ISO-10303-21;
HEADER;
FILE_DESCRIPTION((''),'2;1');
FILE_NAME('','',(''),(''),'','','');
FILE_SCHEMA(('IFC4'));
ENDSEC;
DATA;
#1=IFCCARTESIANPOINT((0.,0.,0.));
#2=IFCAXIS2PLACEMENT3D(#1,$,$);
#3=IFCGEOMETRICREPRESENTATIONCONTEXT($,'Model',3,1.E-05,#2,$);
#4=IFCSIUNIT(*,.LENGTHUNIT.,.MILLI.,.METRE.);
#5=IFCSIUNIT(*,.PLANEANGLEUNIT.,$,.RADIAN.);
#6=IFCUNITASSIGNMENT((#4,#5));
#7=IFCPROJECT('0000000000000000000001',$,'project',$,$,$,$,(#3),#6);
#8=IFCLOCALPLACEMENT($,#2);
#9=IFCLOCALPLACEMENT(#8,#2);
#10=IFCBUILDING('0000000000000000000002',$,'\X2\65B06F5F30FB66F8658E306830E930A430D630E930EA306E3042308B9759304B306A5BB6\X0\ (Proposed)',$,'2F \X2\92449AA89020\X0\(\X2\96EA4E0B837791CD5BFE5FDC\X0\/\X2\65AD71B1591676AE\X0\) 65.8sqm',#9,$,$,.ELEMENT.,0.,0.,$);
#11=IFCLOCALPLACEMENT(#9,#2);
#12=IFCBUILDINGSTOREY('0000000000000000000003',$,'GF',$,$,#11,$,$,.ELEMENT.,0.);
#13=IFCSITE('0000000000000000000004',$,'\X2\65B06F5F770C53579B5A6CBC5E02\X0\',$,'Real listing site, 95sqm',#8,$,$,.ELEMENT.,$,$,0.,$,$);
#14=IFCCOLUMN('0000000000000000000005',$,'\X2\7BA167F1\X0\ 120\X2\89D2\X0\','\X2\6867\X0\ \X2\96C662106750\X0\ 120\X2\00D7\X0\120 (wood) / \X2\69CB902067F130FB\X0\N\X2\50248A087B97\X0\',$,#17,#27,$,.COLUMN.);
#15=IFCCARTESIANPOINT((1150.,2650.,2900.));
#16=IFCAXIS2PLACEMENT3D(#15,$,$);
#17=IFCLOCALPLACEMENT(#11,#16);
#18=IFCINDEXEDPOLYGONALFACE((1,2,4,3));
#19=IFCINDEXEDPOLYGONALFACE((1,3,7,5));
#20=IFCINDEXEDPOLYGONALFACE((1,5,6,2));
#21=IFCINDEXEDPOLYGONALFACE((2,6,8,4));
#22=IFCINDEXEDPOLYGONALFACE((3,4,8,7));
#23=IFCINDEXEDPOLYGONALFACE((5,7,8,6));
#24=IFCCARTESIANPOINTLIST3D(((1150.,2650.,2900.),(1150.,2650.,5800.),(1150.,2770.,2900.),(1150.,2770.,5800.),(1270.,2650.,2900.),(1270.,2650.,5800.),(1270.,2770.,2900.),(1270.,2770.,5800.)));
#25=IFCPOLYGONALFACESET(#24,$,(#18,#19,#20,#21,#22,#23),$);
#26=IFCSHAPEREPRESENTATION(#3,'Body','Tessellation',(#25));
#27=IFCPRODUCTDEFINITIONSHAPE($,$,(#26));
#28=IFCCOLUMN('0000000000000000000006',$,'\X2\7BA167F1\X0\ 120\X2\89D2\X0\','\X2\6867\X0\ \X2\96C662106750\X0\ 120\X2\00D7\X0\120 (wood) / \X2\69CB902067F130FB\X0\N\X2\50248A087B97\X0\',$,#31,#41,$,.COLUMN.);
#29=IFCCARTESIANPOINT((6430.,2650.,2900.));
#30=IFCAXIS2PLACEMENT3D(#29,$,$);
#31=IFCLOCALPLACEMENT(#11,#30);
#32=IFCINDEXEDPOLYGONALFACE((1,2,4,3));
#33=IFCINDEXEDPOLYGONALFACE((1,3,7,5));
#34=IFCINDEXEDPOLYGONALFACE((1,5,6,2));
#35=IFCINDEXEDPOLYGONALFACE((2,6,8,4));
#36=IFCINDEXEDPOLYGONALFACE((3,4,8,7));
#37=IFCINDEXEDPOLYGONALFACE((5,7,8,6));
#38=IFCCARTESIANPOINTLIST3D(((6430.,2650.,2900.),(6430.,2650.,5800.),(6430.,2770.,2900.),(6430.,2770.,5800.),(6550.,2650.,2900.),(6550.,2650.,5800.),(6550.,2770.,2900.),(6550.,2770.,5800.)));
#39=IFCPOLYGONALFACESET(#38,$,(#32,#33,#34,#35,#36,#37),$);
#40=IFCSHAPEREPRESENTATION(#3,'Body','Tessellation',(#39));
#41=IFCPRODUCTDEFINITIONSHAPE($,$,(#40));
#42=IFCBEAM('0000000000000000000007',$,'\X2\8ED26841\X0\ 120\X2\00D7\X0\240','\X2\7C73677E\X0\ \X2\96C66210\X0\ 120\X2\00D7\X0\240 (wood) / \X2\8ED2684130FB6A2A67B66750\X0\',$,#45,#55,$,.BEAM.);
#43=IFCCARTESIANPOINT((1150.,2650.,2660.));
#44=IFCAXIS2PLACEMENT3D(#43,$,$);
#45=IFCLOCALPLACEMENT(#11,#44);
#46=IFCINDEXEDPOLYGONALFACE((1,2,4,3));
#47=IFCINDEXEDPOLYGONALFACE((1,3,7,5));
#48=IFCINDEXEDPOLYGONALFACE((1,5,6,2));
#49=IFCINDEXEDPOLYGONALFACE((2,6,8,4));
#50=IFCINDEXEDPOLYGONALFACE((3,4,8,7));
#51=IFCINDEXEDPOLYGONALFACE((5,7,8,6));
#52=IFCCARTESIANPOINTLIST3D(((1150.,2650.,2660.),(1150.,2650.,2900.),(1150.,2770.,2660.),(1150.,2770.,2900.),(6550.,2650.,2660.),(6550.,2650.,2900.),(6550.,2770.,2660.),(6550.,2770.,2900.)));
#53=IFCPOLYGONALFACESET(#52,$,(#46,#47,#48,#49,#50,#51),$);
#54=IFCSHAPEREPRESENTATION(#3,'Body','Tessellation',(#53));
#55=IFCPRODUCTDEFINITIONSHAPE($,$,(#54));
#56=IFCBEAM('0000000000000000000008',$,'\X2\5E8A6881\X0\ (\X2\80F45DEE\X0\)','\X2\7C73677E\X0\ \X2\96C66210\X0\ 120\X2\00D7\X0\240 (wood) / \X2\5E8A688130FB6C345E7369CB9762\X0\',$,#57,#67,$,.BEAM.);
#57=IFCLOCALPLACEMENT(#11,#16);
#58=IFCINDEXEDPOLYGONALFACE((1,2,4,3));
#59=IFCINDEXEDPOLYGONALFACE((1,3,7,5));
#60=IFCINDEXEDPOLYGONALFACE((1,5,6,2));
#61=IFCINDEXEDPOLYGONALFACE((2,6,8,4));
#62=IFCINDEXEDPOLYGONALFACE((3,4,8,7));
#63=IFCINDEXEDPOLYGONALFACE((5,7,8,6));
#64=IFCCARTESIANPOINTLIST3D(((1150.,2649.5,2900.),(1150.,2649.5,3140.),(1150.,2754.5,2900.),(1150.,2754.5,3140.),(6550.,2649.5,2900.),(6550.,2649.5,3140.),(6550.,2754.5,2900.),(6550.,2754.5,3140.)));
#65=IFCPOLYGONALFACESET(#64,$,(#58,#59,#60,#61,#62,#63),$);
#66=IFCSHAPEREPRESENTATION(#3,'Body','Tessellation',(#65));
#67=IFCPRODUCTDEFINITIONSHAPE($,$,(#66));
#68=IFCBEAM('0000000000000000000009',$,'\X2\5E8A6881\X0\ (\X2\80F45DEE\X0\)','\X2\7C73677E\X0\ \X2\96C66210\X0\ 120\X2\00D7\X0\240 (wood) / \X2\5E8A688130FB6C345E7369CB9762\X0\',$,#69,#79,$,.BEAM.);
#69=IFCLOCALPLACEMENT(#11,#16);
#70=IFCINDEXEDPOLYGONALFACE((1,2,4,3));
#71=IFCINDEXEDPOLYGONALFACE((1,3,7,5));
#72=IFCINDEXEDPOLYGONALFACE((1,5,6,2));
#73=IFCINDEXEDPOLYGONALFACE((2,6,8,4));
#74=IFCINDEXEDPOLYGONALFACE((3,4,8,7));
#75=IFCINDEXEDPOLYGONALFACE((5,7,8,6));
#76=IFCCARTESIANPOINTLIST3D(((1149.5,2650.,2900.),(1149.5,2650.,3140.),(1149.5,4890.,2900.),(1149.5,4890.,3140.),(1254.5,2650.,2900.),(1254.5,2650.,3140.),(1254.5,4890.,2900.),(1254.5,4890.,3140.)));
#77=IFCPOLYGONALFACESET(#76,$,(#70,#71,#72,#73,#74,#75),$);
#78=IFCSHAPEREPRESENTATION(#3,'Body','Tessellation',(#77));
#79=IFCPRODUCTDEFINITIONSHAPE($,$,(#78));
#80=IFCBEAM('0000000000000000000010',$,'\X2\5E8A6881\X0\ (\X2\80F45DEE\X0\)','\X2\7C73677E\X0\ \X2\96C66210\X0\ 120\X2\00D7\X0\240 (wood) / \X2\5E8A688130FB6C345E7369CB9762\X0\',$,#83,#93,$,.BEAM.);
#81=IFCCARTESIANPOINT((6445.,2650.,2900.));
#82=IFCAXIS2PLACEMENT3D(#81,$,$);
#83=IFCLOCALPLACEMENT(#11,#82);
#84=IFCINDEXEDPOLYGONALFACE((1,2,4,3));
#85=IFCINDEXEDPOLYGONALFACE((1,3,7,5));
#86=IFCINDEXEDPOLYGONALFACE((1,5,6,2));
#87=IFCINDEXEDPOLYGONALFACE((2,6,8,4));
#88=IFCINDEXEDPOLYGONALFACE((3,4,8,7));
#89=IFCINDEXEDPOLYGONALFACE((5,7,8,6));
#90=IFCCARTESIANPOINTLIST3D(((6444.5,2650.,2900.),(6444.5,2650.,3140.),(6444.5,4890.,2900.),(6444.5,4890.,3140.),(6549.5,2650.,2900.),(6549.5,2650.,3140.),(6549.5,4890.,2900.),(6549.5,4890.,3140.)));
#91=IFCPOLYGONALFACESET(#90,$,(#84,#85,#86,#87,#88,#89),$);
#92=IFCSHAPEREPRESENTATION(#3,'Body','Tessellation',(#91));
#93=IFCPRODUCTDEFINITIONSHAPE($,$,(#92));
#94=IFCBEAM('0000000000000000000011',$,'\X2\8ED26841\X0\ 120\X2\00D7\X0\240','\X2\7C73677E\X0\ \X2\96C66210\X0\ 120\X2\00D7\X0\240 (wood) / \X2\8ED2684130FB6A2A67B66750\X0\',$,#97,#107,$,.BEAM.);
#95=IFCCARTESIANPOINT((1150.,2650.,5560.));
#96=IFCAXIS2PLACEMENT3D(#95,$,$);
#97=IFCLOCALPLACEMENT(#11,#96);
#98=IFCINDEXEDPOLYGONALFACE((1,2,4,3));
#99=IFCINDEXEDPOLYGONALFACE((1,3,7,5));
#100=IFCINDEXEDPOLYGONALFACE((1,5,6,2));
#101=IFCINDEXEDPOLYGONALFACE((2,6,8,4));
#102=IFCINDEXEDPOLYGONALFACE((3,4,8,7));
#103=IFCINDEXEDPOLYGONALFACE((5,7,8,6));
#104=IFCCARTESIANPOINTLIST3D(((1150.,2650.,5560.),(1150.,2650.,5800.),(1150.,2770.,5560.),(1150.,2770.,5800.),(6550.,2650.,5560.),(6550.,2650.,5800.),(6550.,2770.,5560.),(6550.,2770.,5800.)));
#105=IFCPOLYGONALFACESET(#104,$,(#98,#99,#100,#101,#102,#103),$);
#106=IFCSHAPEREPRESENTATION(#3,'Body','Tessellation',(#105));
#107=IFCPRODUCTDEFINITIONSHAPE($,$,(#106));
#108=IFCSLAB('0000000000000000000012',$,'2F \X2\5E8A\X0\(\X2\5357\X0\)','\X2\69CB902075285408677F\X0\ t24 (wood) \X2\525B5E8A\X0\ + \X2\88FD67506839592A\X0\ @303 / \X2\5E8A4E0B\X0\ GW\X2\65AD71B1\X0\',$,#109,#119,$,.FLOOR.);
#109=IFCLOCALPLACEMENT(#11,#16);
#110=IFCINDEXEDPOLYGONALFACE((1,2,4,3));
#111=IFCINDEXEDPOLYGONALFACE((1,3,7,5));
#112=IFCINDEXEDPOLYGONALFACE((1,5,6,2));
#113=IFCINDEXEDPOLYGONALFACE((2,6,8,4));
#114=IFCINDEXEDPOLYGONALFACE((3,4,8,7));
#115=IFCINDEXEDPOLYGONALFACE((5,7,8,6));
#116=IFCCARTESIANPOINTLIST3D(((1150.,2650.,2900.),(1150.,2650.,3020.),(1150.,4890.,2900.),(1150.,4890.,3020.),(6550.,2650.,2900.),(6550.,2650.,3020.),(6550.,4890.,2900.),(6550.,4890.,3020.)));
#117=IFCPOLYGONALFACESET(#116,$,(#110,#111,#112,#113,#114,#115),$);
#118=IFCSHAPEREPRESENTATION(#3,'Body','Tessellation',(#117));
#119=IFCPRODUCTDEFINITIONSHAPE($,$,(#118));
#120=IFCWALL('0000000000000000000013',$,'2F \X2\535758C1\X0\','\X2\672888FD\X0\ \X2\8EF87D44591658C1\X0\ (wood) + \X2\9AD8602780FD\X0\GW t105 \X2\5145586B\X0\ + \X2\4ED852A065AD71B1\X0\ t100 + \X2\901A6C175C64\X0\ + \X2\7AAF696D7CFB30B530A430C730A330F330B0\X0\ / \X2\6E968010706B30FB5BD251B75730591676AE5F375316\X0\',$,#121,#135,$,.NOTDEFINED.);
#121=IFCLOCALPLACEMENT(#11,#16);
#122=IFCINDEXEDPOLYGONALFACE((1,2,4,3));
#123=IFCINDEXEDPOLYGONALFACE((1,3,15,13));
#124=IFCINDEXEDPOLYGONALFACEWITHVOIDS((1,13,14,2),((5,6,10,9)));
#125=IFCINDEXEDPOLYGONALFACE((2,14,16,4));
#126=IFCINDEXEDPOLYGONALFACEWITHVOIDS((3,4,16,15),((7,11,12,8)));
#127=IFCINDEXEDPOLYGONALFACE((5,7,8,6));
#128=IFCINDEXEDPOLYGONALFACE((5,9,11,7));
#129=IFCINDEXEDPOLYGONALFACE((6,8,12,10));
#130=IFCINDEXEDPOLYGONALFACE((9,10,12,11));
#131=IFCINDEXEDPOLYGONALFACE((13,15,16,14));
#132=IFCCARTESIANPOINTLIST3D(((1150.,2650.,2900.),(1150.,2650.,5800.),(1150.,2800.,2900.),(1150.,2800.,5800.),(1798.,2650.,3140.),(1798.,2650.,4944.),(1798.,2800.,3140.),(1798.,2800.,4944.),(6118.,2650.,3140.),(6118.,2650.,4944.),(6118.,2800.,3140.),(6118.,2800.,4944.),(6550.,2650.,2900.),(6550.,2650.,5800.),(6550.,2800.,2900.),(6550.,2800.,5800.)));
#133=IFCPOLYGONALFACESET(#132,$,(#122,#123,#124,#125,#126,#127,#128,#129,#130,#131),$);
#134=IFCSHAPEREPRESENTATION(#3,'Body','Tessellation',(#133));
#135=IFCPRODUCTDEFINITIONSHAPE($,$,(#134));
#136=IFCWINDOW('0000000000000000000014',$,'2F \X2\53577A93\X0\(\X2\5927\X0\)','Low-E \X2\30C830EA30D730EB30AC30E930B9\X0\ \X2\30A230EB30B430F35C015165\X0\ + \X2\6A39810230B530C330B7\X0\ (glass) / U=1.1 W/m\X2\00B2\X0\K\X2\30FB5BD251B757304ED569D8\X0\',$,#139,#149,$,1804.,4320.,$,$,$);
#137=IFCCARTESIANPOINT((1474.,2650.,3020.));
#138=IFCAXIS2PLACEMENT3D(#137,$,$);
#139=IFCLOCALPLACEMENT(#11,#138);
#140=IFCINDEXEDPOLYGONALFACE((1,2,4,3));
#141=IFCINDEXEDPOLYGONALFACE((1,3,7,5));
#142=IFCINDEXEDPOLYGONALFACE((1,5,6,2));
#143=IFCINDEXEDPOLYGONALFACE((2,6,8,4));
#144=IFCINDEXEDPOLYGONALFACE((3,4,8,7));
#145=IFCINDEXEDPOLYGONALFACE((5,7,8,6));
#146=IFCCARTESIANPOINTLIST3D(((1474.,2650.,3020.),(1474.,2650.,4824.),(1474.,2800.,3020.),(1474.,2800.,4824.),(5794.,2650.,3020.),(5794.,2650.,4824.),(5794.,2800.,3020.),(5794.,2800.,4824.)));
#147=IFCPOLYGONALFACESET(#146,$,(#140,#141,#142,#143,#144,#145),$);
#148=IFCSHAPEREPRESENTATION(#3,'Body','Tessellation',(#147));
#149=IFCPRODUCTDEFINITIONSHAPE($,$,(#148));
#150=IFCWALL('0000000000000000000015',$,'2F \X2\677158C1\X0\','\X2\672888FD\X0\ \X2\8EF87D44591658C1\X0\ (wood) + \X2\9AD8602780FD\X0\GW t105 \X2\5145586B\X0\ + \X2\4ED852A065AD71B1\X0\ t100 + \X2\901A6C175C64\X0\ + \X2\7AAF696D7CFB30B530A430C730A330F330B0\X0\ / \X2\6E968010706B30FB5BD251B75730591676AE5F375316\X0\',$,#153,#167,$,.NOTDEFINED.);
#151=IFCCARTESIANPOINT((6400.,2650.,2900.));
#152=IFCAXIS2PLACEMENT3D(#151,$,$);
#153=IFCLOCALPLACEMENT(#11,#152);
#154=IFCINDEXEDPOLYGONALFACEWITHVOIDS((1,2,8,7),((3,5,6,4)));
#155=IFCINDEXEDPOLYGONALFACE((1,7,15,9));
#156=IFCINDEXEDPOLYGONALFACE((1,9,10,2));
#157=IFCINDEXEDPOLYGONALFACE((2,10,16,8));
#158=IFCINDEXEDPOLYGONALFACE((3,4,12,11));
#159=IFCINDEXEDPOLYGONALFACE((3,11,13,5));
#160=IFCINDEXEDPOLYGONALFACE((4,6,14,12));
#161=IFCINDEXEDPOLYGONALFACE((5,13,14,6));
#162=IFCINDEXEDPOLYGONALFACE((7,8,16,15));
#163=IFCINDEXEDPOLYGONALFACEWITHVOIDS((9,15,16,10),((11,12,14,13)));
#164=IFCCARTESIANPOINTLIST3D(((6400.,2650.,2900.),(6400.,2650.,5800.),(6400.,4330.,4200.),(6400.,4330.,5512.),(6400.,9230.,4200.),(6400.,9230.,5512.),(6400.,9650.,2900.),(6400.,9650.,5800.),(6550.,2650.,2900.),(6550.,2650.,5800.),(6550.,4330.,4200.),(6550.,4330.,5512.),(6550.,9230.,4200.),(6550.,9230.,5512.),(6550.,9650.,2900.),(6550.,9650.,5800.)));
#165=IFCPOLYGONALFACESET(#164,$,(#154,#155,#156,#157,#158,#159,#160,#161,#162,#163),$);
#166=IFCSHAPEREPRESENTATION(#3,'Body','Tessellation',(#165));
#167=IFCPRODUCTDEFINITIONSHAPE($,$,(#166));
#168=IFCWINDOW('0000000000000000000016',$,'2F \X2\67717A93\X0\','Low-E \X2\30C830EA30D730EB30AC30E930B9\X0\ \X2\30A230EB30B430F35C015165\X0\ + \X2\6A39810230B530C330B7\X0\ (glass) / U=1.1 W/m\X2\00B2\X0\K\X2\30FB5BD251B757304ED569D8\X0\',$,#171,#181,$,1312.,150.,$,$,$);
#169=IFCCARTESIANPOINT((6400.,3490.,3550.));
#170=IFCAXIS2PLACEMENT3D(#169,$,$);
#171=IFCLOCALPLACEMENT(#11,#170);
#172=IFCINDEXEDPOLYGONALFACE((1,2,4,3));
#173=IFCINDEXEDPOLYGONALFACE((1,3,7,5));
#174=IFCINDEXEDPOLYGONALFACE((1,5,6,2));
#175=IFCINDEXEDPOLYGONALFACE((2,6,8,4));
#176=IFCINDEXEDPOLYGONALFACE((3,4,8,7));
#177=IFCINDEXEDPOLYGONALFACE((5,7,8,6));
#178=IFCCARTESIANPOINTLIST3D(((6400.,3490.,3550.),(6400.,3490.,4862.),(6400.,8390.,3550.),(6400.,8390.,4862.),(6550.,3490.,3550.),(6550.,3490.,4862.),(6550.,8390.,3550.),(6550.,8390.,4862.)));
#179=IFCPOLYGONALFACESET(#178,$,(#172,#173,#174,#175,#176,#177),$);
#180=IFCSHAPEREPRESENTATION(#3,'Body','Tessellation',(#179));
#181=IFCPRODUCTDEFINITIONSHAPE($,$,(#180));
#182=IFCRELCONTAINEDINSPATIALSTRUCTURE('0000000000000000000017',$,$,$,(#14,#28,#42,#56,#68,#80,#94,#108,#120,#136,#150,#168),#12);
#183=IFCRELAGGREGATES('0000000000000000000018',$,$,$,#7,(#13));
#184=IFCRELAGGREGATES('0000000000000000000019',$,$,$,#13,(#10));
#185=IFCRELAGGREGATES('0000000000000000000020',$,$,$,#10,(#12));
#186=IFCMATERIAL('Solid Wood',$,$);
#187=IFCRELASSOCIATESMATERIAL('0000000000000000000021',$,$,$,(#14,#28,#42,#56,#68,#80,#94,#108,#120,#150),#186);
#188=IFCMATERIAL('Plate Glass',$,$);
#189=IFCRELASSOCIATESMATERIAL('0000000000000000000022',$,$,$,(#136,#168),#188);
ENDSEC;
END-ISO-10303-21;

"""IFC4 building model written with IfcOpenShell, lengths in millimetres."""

from ifc_helpers import new_model, si_unit, frame, frame_2d, origin, place, context, project, spatial, rectangle, extrude, material, element, fill, save


model = new_model("IFC4")

# Units and contexts
model_context = context("Model", 3, precision=1e-05, world=origin())
ifc_project = project(units=[si_unit("LENGTHUNIT", "METRE", prefix="MILLI"), si_unit("PLANEANGLEUNIT", "RADIAN")], contexts=[model_context])

# Site, building, storey
site_placement = place(None, origin())
site = spatial("IfcSite", under=ifc_project, at=site_placement, Name="新潟県南魚沼市", ObjectType="Real listing site, 95sqm", CompositionType="ELEMENT", RefElevation=0.0)
building_placement = place(site_placement, origin())
building = spatial("IfcBuilding", under=site, at=building_placement, Name="新潟・書斎とライブラリのある静かな家 (Proposed)", ObjectType="2F 鉄骨造(雪下荷重対応/断熱外皮) 65.8sqm", CompositionType="ELEMENT", ElevationOfRefHeight=0.0, ElevationOfTerrain=0.0)
storey_placement = place(building_placement, origin())
storey = spatial("IfcBuildingStorey", under=building, at=storey_placement, Name="GF", CompositionType="ELEMENT", Elevation=0.0)

# Columns
ifc_material_1 = material(Name="Solid Wood")
column_1_placement = place(storey_placement, frame((1150.0, 2650.0, 2900.0)))
element("IfcColumn", 1, at=column_1_placement, inside=storey, material=ifc_material_1, Name="管柱 120角", Description="桧 集成材 120×120 (wood) / 構造柱・N値計算", PredefinedType="COLUMN", context=model_context, shape_type="SweptSolid", body=[
    extrude(rectangle(XDim=120.0, YDim=120.0, at=frame_2d((60.0, 60.0))), frame((1150.0, 2650.0, 2900.0)), (0.0, 0.0, 1.0), 2900.0),
])
column_2_placement = place(storey_placement, frame((6430.0, 2650.0, 2900.0)))
element("IfcColumn", 2, at=column_2_placement, inside=storey, material=ifc_material_1, Name="管柱 120角", Description="桧 集成材 120×120 (wood) / 構造柱・N値計算", PredefinedType="COLUMN", context=model_context, shape_type="SweptSolid", body=[
    extrude(rectangle(XDim=120.0, YDim=120.0, at=frame_2d((60.0, 60.0))), frame((6430.0, 2650.0, 2900.0)), (0.0, 0.0, 1.0), 2900.0),
])

# Beams
beam_1_placement = place(storey_placement, frame((1150.0, 2650.0, 2660.0)))
element("IfcBeam", 3, at=beam_1_placement, inside=storey, material=ifc_material_1, Name="軒桁 120×240", Description="米松 集成 120×240 (wood) / 軒桁・横架材", PredefinedType="BEAM", context=model_context, shape_type="SweptSolid", body=[
    extrude(rectangle(XDim=5400.0, YDim=120.0, at=frame_2d((2700.0, 60.0))), frame((1150.0, 2650.0, 2660.0)), (0.0, 0.0, 1.0), 240.0),
])
beam_2_placement = place(storey_placement, frame((1150.0, 2650.0, 2900.0)))
element("IfcBeam", 4, at=beam_2_placement, inside=storey, material=ifc_material_1, Name="床梁 (胴差)", Description="米松 集成 120×240 (wood) / 床梁・水平構面", PredefinedType="BEAM", context=model_context, shape_type="SweptSolid", body=[
    extrude(rectangle(XDim=5400.0, YDim=105.0, at=frame_2d((2700.0, 52.0))), frame((1150.0, 2650.0, 2900.0)), (0.0, 0.0, 1.0), 240.0),
])
beam_3_placement = place(storey_placement, frame((1150.0, 2650.0, 2900.0)))
element("IfcBeam", 5, at=beam_3_placement, inside=storey, material=ifc_material_1, Name="床梁 (胴差)", Description="米松 集成 120×240 (wood) / 床梁・水平構面", PredefinedType="BEAM", context=model_context, shape_type="SweptSolid", body=[
    extrude(rectangle(XDim=105.0, YDim=2240.0, at=frame_2d((52.0, 1120.0))), frame((1150.0, 2650.0, 2900.0)), (0.0, 0.0, 1.0), 240.0),
])
beam_4_placement = place(storey_placement, frame((6445.0, 2650.0, 2900.0)))
element("IfcBeam", 6, at=beam_4_placement, inside=storey, material=ifc_material_1, Name="床梁 (胴差)", Description="米松 集成 120×240 (wood) / 床梁・水平構面", PredefinedType="BEAM", context=model_context, shape_type="SweptSolid", body=[
    extrude(rectangle(XDim=105.0, YDim=2240.0, at=frame_2d((52.0, 1120.0))), frame((6445.0, 2650.0, 2900.0)), (0.0, 0.0, 1.0), 240.0),
])
beam_5_placement = place(storey_placement, frame((1150.0, 2650.0, 5560.0)))
element("IfcBeam", 7, at=beam_5_placement, inside=storey, material=ifc_material_1, Name="軒桁 120×240", Description="米松 集成 120×240 (wood) / 軒桁・横架材", PredefinedType="BEAM", context=model_context, shape_type="SweptSolid", body=[
    extrude(rectangle(XDim=5400.0, YDim=120.0, at=frame_2d((2700.0, 60.0))), frame((1150.0, 2650.0, 5560.0)), (0.0, 0.0, 1.0), 240.0),
])

# Slab
slab_placement = place(storey_placement, frame((1150.0, 2650.0, 2900.0)))
element("IfcSlab", 8, at=slab_placement, inside=storey, material=ifc_material_1, Name="2F 床(南)", Description="構造用合板 t24 (wood) 剛床 + 製材根太 @303 / 床下 GW断熱", PredefinedType="FLOOR", context=model_context, shape_type="SweptSolid", body=[
    extrude(rectangle(XDim=5400.0, YDim=2240.0, at=frame_2d((2700.0, 1120.0))), frame((1150.0, 2650.0, 2900.0)), (0.0, 0.0, 1.0), 120.0),
])

# Walls, openings, windows
wall_1_placement = place(storey_placement, frame((1150.0, 2650.0, 2900.0)))
wall_1 = element("IfcWall", 9, at=wall_1_placement, inside=storey, material=ifc_material_1, Name="2F 南壁", Description="木製 軸組外壁 (wood) + 高性能GW t105 充填 + 付加断熱 t100 + 通気層 + 窯業系サイディング / 準耐火・寒冷地外皮強化", PredefinedType="NOTDEFINED", context=model_context, shape_type="SweptSolid", body=[
    extrude(rectangle(XDim=5400.0, YDim=150.0, at=frame_2d((2700.0, 75.0))), frame((1150.0, 2650.0, 2900.0)), (0.0, 0.0, 1.0), 2900.0),
])
opening_1_placement = place(storey_placement, frame((1474.0, 2650.0, 3020.0)))
opening_1 = element("IfcOpeningElement", 10, at=opening_1_placement, cuts=wall_1, PredefinedType="NOTDEFINED", context=model_context, shape_type="SweptSolid", body=[
    extrude(rectangle(XDim=4320.0, YDim=150.0, at=frame_2d((2160.0, 75.0))), frame((1474.0, 2650.0, 3020.0)), (0.0, 0.0, 1.0), 1804.0),
])
ifc_material_2 = material(Name="Plate Glass")
window_1_placement = place(storey_placement, frame((1474.0, 2650.0, 3020.0)))
window_1 = element("IfcWindow", 11, at=window_1_placement, inside=storey, material=ifc_material_2, Name="2F 南窓(大)", Description="Low-E トリプルガラス アルゴン封入 + 樹脂サッシ (glass) / U=1.1 W/m²K・寒冷地仕様", OverallHeight=1804.0, OverallWidth=4320.0, context=model_context, shape_type="SweptSolid", body=[
    extrude(rectangle(XDim=4320.0, YDim=150.0, at=frame_2d((2160.0, 75.0))), frame((1474.0, 2650.0, 3020.0)), (0.0, 0.0, 1.0), 1804.0),
])
fill(opening_1, window_1)
wall_2_placement = place(storey_placement, frame((6400.0, 2650.0, 2900.0)))
wall_2 = element("IfcWall", 12, at=wall_2_placement, inside=storey, material=ifc_material_1, Name="2F 東壁", Description="木製 軸組外壁 (wood) + 高性能GW t105 充填 + 付加断熱 t100 + 通気層 + 窯業系サイディング / 準耐火・寒冷地外皮強化", PredefinedType="NOTDEFINED", context=model_context, shape_type="SweptSolid", body=[
    extrude(rectangle(XDim=150.0, YDim=7000.0, at=frame_2d((75.0, 3500.0))), frame((6400.0, 2650.0, 2900.0)), (0.0, 0.0, 1.0), 2900.0),
])
opening_2_placement = place(storey_placement, frame((6400.0, 3490.0, 3550.0)))
opening_2 = element("IfcOpeningElement", 13, at=opening_2_placement, cuts=wall_2, PredefinedType="NOTDEFINED", context=model_context, shape_type="SweptSolid", body=[
    extrude(rectangle(XDim=150.0, YDim=4900.0, at=frame_2d((75.0, 2450.0))), frame((6400.0, 3490.0, 3550.0)), (0.0, 0.0, 1.0), 1312.0),
])
window_2_placement = place(storey_placement, frame((6400.0, 3490.0, 3550.0)))
window_2 = element("IfcWindow", 14, at=window_2_placement, inside=storey, material=ifc_material_2, Name="2F 東窓", Description="Low-E トリプルガラス アルゴン封入 + 樹脂サッシ (glass) / U=1.1 W/m²K・寒冷地仕様", OverallHeight=1312.0, OverallWidth=150.0, context=model_context, shape_type="SweptSolid", body=[
    extrude(rectangle(XDim=150.0, YDim=4900.0, at=frame_2d((75.0, 2450.0))), frame((6400.0, 3490.0, 3550.0)), (0.0, 0.0, 1.0), 1312.0),
])
fill(opening_2, window_2)

save(model, "model.ifc")
